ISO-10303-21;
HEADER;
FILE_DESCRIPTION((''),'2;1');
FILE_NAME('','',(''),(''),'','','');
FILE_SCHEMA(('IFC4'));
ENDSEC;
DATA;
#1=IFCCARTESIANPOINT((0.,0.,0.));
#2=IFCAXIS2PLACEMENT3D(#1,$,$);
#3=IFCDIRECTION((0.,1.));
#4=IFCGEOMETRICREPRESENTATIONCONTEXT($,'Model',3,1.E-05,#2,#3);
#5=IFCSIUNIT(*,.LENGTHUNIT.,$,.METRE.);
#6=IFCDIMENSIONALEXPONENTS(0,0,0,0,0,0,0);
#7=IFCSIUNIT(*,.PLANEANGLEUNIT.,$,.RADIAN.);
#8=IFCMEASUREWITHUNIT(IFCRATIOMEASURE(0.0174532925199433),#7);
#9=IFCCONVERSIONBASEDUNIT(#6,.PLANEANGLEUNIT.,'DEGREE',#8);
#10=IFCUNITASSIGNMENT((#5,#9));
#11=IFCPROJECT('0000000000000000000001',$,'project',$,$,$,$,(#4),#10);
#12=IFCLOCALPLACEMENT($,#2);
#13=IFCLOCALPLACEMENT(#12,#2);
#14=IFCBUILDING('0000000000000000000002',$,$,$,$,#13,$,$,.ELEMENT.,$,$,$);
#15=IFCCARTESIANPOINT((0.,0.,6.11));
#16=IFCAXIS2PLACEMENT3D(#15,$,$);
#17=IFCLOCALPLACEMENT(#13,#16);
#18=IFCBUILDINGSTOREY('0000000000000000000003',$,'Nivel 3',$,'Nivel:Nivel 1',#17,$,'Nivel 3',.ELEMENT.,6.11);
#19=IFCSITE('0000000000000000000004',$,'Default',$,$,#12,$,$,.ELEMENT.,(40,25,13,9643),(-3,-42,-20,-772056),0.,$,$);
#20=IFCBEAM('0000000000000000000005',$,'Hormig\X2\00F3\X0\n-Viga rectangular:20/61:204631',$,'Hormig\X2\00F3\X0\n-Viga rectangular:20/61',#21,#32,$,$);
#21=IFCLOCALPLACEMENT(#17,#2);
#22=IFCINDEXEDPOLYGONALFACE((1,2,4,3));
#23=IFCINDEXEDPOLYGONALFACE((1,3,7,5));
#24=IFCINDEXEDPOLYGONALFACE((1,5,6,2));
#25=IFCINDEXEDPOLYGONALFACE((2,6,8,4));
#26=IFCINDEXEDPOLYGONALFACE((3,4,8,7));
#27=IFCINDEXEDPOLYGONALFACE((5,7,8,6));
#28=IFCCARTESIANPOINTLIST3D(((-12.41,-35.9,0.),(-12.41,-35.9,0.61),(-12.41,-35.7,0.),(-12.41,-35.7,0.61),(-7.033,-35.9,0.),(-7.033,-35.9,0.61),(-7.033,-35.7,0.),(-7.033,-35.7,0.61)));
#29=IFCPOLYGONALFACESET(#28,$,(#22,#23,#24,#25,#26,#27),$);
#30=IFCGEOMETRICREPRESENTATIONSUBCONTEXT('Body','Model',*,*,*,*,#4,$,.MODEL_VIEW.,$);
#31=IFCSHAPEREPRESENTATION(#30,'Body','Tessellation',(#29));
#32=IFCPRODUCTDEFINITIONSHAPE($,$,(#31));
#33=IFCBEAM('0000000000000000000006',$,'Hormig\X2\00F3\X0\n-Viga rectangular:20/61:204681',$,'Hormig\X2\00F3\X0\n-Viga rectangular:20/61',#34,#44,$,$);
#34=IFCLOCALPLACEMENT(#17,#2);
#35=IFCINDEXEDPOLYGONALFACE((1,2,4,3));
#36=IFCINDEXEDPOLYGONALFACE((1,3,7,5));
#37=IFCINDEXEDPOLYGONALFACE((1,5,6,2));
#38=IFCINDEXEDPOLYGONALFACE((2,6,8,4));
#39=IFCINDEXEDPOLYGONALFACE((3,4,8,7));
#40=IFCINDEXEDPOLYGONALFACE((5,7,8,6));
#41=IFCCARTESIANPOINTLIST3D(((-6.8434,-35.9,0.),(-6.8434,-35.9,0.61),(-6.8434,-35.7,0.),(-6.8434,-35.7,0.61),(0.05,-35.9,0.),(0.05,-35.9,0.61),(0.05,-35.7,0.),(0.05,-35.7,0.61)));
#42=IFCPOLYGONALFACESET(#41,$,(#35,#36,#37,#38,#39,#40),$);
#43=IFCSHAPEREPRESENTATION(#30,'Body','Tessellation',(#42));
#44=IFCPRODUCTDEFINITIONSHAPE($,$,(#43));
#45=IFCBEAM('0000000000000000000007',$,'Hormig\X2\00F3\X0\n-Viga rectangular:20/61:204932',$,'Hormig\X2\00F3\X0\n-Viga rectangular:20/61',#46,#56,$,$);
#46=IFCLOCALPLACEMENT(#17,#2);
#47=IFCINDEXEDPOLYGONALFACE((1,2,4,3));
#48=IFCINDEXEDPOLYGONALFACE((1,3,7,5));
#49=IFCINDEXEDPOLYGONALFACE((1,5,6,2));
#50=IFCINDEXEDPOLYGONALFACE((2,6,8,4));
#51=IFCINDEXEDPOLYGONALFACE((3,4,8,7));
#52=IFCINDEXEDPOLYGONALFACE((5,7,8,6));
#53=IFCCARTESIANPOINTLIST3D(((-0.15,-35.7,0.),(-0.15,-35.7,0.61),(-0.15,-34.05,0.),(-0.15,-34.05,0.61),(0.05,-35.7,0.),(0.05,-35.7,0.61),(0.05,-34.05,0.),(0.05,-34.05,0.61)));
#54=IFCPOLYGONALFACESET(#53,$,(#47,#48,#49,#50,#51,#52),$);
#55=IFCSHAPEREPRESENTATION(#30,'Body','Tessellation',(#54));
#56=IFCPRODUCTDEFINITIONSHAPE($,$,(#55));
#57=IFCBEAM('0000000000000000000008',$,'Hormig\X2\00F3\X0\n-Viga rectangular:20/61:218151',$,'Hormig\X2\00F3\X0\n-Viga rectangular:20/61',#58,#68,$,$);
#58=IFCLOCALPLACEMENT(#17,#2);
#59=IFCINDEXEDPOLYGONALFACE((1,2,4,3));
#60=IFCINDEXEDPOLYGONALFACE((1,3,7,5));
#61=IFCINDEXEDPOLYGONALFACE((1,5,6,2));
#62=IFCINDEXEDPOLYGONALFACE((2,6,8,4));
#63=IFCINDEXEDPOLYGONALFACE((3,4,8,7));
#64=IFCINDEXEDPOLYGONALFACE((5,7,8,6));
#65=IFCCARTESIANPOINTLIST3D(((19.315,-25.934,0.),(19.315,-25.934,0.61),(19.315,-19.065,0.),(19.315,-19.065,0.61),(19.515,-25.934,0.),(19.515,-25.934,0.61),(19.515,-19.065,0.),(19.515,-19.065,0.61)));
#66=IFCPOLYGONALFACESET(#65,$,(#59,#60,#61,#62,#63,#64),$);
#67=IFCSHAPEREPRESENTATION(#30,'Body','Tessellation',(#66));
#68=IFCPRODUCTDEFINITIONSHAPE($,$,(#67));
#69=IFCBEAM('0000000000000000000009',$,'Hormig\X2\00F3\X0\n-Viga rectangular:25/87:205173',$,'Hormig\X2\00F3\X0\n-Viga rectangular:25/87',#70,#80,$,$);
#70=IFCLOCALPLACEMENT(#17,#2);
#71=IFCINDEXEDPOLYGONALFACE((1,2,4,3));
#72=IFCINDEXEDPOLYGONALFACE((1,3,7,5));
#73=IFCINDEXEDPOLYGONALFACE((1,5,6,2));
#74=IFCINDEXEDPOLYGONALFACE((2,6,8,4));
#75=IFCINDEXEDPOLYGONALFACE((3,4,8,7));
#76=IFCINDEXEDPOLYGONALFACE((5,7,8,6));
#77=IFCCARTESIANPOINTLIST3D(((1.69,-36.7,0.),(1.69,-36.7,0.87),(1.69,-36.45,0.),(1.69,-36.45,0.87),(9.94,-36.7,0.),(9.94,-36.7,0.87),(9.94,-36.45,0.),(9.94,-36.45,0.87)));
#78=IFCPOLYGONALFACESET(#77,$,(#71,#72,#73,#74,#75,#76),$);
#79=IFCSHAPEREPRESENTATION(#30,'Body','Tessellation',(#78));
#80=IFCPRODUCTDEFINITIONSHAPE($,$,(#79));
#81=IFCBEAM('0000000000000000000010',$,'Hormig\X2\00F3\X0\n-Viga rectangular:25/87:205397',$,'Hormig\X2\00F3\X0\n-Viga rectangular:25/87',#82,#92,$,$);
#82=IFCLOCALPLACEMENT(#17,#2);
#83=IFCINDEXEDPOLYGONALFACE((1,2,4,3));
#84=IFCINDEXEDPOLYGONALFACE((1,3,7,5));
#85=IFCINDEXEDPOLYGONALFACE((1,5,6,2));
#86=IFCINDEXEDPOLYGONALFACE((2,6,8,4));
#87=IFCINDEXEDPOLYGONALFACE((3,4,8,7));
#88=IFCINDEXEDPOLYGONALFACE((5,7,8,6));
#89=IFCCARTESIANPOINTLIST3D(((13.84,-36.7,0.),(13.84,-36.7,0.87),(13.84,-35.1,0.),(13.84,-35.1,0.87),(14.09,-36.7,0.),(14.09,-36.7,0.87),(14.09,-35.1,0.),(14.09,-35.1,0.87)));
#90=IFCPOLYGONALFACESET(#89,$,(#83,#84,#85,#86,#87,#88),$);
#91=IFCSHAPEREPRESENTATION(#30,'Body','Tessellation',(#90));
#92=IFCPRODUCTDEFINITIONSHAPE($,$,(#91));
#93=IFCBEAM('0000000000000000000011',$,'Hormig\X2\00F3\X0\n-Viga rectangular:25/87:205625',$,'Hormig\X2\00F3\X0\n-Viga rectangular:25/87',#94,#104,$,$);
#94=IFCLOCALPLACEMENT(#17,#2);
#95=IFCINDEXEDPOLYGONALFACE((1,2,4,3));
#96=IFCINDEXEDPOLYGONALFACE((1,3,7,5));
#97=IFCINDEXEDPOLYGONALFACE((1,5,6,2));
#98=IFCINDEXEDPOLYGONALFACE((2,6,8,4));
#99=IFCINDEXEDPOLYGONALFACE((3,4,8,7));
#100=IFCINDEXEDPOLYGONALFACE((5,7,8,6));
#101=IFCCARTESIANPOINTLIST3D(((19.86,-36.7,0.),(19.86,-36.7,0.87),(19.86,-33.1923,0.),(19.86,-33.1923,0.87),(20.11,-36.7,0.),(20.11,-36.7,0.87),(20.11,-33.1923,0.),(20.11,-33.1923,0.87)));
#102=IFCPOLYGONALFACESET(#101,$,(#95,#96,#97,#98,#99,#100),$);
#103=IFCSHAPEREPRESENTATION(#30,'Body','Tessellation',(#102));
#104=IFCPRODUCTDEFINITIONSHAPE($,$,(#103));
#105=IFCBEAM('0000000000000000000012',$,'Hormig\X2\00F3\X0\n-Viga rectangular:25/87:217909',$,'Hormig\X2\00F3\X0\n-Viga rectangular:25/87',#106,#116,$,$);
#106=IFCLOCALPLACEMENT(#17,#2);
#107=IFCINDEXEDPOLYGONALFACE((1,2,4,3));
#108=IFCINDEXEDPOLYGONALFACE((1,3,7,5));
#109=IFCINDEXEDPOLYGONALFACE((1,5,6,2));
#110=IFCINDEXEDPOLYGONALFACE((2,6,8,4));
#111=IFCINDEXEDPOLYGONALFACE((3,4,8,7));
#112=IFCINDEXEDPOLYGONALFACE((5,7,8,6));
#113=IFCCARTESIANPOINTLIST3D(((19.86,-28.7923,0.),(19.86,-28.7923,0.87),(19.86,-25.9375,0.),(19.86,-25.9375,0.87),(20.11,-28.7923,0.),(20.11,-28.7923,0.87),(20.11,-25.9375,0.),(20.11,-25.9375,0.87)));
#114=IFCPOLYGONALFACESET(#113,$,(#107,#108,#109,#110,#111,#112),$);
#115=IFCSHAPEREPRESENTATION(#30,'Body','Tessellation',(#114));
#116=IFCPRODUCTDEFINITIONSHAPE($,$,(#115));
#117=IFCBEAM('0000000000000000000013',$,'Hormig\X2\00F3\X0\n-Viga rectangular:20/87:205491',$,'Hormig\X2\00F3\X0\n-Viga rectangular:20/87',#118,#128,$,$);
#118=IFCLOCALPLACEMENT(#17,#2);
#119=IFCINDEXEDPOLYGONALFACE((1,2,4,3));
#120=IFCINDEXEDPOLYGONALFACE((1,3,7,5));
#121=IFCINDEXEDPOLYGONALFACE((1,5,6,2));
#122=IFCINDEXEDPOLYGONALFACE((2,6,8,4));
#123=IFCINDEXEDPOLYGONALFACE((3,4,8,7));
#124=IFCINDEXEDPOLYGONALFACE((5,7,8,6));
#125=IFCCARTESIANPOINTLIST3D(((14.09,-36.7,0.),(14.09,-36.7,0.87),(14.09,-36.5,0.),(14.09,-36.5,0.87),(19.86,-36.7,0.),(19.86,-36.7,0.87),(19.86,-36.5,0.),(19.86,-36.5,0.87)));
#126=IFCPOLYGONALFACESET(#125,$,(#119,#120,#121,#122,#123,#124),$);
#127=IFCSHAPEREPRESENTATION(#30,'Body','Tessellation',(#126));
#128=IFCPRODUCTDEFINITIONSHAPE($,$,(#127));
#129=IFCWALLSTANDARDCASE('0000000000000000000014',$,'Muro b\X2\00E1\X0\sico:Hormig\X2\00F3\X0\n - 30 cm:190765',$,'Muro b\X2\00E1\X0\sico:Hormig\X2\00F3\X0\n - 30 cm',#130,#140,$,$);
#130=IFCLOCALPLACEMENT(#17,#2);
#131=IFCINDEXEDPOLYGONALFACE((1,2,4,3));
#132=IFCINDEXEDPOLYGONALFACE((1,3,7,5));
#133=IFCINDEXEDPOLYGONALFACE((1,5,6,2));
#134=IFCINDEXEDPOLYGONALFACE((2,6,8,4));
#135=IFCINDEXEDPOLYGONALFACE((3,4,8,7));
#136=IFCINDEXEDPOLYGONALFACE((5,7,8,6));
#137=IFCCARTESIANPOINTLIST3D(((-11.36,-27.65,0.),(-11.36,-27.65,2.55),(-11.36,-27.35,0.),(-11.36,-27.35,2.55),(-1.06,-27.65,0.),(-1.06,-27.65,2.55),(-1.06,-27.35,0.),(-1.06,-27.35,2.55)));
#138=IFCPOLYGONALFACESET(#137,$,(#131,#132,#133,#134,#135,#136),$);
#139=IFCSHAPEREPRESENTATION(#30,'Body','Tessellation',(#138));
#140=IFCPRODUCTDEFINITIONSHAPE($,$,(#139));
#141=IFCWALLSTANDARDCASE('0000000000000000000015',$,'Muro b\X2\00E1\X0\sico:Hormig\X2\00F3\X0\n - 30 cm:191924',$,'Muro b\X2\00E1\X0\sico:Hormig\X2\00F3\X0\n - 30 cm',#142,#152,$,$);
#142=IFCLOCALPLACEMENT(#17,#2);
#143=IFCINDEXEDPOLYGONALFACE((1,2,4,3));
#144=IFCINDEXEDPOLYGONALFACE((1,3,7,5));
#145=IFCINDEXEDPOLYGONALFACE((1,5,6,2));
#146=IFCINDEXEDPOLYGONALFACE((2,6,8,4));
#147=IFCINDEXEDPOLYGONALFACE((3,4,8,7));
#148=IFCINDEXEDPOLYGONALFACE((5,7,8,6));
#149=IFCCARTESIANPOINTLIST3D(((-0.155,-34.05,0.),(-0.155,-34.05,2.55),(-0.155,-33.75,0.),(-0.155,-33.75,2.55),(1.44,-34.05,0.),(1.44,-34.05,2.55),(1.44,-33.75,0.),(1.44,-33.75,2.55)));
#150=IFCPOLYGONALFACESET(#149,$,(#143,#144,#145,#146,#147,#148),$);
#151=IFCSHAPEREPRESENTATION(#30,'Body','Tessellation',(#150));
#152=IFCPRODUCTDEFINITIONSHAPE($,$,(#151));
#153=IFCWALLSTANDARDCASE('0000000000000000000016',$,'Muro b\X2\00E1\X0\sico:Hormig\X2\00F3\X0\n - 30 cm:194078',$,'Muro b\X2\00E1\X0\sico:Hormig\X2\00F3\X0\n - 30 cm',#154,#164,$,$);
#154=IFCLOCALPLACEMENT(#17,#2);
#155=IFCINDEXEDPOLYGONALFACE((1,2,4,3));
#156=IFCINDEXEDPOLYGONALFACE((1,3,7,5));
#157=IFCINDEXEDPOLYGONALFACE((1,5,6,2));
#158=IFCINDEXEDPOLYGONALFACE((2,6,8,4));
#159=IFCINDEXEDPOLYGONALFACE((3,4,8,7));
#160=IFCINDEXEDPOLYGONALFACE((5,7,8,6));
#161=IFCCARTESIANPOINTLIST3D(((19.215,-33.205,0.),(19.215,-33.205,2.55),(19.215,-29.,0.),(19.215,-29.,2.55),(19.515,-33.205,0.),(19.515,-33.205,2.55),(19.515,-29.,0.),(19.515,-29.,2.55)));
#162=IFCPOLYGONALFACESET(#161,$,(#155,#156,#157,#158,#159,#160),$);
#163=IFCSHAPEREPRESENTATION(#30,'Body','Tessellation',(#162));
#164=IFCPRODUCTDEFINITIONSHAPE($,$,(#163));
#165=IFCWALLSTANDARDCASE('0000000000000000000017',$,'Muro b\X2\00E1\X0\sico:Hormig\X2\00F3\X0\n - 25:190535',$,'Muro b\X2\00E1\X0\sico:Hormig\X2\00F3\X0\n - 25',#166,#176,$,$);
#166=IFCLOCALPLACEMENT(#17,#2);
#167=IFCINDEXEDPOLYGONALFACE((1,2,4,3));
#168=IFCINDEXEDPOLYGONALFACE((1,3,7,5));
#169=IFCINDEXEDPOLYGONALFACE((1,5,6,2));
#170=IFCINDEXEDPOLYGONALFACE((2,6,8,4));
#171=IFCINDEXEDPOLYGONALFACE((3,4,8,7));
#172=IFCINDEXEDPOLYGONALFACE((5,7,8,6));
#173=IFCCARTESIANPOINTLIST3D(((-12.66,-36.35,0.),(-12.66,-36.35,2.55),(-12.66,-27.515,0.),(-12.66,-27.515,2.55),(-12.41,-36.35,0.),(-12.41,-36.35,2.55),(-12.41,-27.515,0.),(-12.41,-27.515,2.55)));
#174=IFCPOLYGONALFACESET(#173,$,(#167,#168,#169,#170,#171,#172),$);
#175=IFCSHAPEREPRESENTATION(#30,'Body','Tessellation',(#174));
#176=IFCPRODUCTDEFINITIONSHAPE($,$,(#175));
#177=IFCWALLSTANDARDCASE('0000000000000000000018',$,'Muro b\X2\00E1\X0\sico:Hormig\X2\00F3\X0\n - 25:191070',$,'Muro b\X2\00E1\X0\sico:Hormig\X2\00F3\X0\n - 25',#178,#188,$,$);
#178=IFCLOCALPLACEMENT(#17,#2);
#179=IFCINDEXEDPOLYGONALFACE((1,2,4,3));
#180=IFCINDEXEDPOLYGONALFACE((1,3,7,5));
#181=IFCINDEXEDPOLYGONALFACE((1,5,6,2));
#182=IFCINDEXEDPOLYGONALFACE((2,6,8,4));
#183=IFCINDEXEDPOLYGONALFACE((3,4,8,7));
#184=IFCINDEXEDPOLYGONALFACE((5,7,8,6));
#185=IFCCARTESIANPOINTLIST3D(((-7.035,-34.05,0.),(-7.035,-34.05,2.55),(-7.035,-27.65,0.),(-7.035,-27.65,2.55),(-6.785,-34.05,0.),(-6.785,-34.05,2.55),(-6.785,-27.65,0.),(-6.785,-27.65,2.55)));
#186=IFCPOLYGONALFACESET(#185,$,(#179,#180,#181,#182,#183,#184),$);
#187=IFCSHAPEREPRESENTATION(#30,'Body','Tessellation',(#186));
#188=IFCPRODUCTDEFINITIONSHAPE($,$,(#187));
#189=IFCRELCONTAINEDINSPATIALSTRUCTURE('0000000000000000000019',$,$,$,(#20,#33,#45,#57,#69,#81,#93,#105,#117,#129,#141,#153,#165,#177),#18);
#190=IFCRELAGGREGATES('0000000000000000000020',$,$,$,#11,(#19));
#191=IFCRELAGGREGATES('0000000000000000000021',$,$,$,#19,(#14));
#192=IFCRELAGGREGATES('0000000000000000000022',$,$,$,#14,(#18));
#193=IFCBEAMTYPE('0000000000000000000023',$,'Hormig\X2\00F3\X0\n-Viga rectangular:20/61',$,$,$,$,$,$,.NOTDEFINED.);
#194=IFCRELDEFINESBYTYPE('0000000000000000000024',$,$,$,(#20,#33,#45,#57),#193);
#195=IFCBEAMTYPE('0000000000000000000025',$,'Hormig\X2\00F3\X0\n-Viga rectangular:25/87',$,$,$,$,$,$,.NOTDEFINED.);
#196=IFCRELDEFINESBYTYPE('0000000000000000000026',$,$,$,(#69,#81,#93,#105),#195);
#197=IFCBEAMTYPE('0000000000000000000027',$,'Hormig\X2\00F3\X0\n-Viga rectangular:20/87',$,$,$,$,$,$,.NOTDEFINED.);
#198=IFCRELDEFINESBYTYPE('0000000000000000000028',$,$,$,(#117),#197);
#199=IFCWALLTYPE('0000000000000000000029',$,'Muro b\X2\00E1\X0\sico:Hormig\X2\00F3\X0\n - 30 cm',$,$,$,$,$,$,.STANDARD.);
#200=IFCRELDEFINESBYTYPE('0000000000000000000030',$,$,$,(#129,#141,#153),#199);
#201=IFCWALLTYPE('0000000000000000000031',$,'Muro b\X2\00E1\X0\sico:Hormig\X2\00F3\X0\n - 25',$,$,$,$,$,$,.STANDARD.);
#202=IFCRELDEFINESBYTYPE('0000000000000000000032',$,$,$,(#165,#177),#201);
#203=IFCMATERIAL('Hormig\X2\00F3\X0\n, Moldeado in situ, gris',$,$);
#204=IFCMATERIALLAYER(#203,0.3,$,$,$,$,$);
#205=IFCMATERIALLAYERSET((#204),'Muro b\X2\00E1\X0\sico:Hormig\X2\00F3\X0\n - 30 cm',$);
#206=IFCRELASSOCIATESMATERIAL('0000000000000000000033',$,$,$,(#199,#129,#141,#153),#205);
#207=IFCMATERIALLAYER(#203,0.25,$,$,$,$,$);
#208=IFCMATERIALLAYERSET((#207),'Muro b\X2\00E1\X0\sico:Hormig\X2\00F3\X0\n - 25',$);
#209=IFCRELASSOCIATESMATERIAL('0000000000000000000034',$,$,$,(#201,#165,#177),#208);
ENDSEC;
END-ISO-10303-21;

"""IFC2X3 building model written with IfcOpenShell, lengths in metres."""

from ifc_helpers import new_model, entity, si_unit, converted_unit, direction, frame, frame_2d, origin, origin_2d_with_axis, place, context, subcontext, project, spatial, rectangle, extrude, material, layer, layer_set, layer_usage, type_object, element, save


model = new_model("IFC2X3")

# Units and contexts
model_context = context("Model", 3, precision=1e-05, world=origin(), true_north=direction((0.0, 1.0)))
body_context = subcontext(model_context, "Body", "Model", "MODEL_VIEW")
ifc_project = project(units=[si_unit("LENGTHUNIT", "METRE"), converted_unit("PLANEANGLEUNIT", "DEGREE", entity("IfcRatioMeasure", 0.0174532925199433), si_unit("PLANEANGLEUNIT", "RADIAN"), dimensions=[0, 0, 0, 0, 0, 0, 0])], contexts=[model_context])

# Site, building, storey
site_placement = place(None, origin())
site = spatial("IfcSite", under=ifc_project, at=site_placement, Name="Default", CompositionType="ELEMENT", RefLatitude=(40, 25, 13, 9643), RefLongitude=(-3, -42, -20, -772056), RefElevation=0.0)
building_placement = place(site_placement, origin())
building = spatial("IfcBuilding", under=site, at=building_placement, CompositionType="ELEMENT")
storey_placement = place(building_placement, frame((0.0, 0.0, 6.11)))
storey = spatial("IfcBuildingStorey", under=building, at=storey_placement, Name="Nivel 3", ObjectType="Nivel:Nivel 1", LongName="Nivel 3", CompositionType="ELEMENT", Elevation=6.11)

# Beams
beam_type_1 = type_object("IfcBeamType", Name="Hormigón-Viga rectangular:20/61", PredefinedType="NOTDEFINED")
beam_1_placement = place(storey_placement, frame((-12.4857, -35.8, 0.61)))
element("IfcBeam", 1, at=beam_1_placement, inside=storey, type_object=beam_type_1, Name="Hormigón-Viga rectangular:20/61:204631", ObjectType="Hormigón-Viga rectangular:20/61", context=body_context, shape_type="SweptSolid", body=[
    extrude(rectangle(XDim=0.61, YDim=0.2, at=frame_2d((0.0, 0.0), x_axis=(1.0, 0.0))), frame((0.0757, 0.0, -0.305), z_axis=(1.0, 0.0, 0.0), x_axis=(0.0, 0.0, -1.0)), (0.0, 0.0, 1.0), 5.377),
])
beam_2_placement = place(storey_placement, frame((-6.8307, -35.8, 0.61)))
element("IfcBeam", 2, at=beam_2_placement, inside=storey, type_object=beam_type_1, Name="Hormigón-Viga rectangular:20/61:204681", ObjectType="Hormigón-Viga rectangular:20/61", context=body_context, shape_type="SweptSolid", body=[
    extrude(rectangle(XDim=0.61, YDim=0.2, at=frame_2d((0.0, 0.0), x_axis=(1.0, 0.0))), frame((-0.0127, 0.0, -0.305), z_axis=(1.0, 0.0, 0.0), x_axis=(0.0, 0.0, -1.0)), (0.0, 0.0, 1.0), 6.8934),
])
beam_3_placement = place(storey_placement, frame((-0.05, -35.8, 0.61), z_axis=(0.0, 0.0, 1.0), x_axis=(0.0, 1.0, 0.0)))
element("IfcBeam", 3, at=beam_3_placement, inside=storey, type_object=beam_type_1, Name="Hormigón-Viga rectangular:20/61:204932", ObjectType="Hormigón-Viga rectangular:20/61", context=body_context, shape_type="SweptSolid", body=[
    extrude(rectangle(XDim=0.61, YDim=0.2, at=origin_2d_with_axis()), frame((0.1, 0.0, -0.305), z_axis=(1.0, 0.0, 0.0), x_axis=(0.0, 0.0, -1.0)), (0.0, 0.0, 1.0), 1.65),
])
beam_4_placement = place(storey_placement, frame((19.415, -25.9216, 0.61), z_axis=(0.0, 0.0, 1.0), x_axis=(0.0, 1.0, 0.0)))
element("IfcBeam", 4, at=beam_4_placement, inside=storey, type_object=beam_type_1, Name="Hormigón-Viga rectangular:20/61:218151", ObjectType="Hormigón-Viga rectangular:20/61", context=body_context, shape_type="SweptSolid", body=[
    extrude(rectangle(XDim=0.61, YDim=0.2, at=origin_2d_with_axis()), frame((-0.0124, 0.0, -0.305), z_axis=(1.0, 0.0, 0.0), x_axis=(0.0, 0.0, -1.0)), (0.0, 0.0, 1.0), 6.869),
])
beam_type_2 = type_object("IfcBeamType", Name="Hormigón-Viga rectangular:25/87", PredefinedType="NOTDEFINED")
beam_5_placement = place(storey_placement, frame((1.565, -36.575, 0.87)))
element("IfcBeam", 5, at=beam_5_placement, inside=storey, type_object=beam_type_2, Name="Hormigón-Viga rectangular:25/87:205173", ObjectType="Hormigón-Viga rectangular:25/87", context=body_context, shape_type="SweptSolid", body=[
    extrude(rectangle(XDim=0.87, YDim=0.25, at=frame_2d((0.0, 0.0), x_axis=(1.0, 0.0))), frame((0.125, 0.0, -0.435), z_axis=(1.0, 0.0, 0.0), x_axis=(0.0, 0.0, -1.0)), (0.0, 0.0, 1.0), 8.25),
])
beam_6_placement = place(storey_placement, frame((13.965, -34.975, 0.87), z_axis=(0.0, 0.0, 1.0), x_axis=(0.0, -1.0, 0.0)))
element("IfcBeam", 6, at=beam_6_placement, inside=storey, type_object=beam_type_2, Name="Hormigón-Viga rectangular:25/87:205397", ObjectType="Hormigón-Viga rectangular:25/87", context=body_context, shape_type="SweptSolid", body=[
    extrude(rectangle(XDim=0.87, YDim=0.25, at=origin_2d_with_axis()), frame((0.125, 0.0, -0.435), z_axis=(1.0, 0.0, 0.0), x_axis=(0.0, 0.0, -1.0)), (0.0, 0.0, 1.0), 1.6),
])
beam_7_placement = place(storey_placement, frame((19.985, -33.1923, 0.87), z_axis=(0.0, 0.0, 1.0), x_axis=(0.0, -1.0, 0.0)))
element("IfcBeam", 7, at=beam_7_placement, inside=storey, type_object=beam_type_2, Name="Hormigón-Viga rectangular:25/87:205625", ObjectType="Hormigón-Viga rectangular:25/87", context=body_context, shape_type="SweptSolid", body=[
    extrude(rectangle(XDim=0.87, YDim=0.25, at=origin_2d_with_axis()), frame((0.0, 0.0, -0.435), z_axis=(1.0, 0.0, 0.0), x_axis=(0.0, 0.0, -1.0)), (0.0, 0.0, 1.0), 3.5077),
])
beam_8_placement = place(storey_placement, frame((19.985, -25.95, 0.87), z_axis=(0.0, 0.0, 1.0), x_axis=(0.0, -1.0, 0.0)))
element("IfcBeam", 8, at=beam_8_placement, inside=storey, type_object=beam_type_2, Name="Hormigón-Viga rectangular:25/87:217909", ObjectType="Hormigón-Viga rectangular:25/87", context=body_context, shape_type="SweptSolid", body=[
    extrude(rectangle(XDim=0.87, YDim=0.25, at=origin_2d_with_axis()), frame((-0.0126, 0.0, -0.435), z_axis=(1.0, 0.0, 0.0), x_axis=(0.0, 0.0, -1.0)), (0.0, 0.0, 1.0), 2.8548),
])
beam_type_3 = type_object("IfcBeamType", Name="Hormigón-Viga rectangular:20/87", PredefinedType="NOTDEFINED")
beam_9_placement = place(storey_placement, frame((13.965, -36.6, 0.87)))
element("IfcBeam", 9, at=beam_9_placement, inside=storey, type_object=beam_type_3, Name="Hormigón-Viga rectangular:20/87:205491", ObjectType="Hormigón-Viga rectangular:20/87", context=body_context, shape_type="SweptSolid", body=[
    extrude(rectangle(XDim=0.87, YDim=0.2, at=frame_2d((0.0, 0.0), x_axis=(1.0, 0.0))), frame((0.125, 0.0, -0.435), z_axis=(1.0, 0.0, 0.0), x_axis=(0.0, 0.0, -1.0)), (0.0, 0.0, 1.0), 5.77),
])

# Walls
ifc_material = material(Name="Hormigón, Moldeado in situ, gris")
ifc_layer_1 = layer(ifc_material, 0.3)
ifc_layer_set_1 = layer_set([ifc_layer_1], Name="Muro básico:Hormigón - 30 cm")
ifc_layer_usage_1 = layer_usage(ifc_layer_set_1, "AXIS2", "NEGATIVE", 0.15)
wall_type_1 = type_object("IfcWallType", Name="Muro básico:Hormigón - 30 cm", PredefinedType="STANDARD", material=ifc_layer_set_1)
wall_1_placement = place(storey_placement, frame((-11.36, -27.5, 0.0)))
element("IfcWallStandardCase", 10, at=wall_1_placement, inside=storey, type_object=wall_type_1, material=ifc_layer_usage_1, Name="Muro básico:Hormigón - 30 cm:190765", ObjectType="Muro básico:Hormigón - 30 cm", context=body_context, shape_type="SweptSolid", body=[
    extrude(rectangle(XDim=10.3, YDim=0.3, at=frame_2d((5.15, 0.0), x_axis=(-1.0, 0.0))), origin(), (0.0, 0.0, 1.0), 2.55),
])
ifc_layer_usage_2 = layer_usage(ifc_layer_set_1, "AXIS2", "NEGATIVE", 0.15)
wall_2_placement = place(storey_placement, frame((-0.155, -33.9, 0.0)))
element("IfcWallStandardCase", 11, at=wall_2_placement, inside=storey, type_object=wall_type_1, material=ifc_layer_usage_2, Name="Muro básico:Hormigón - 30 cm:191924", ObjectType="Muro básico:Hormigón - 30 cm", context=body_context, shape_type="SweptSolid", body=[
    extrude(rectangle(XDim=1.595, YDim=0.3, at=frame_2d((0.7975, 0.0), x_axis=(-1.0, 0.0))), origin(), (0.0, 0.0, 1.0), 2.55),
])
ifc_layer_usage_3 = layer_usage(ifc_layer_set_1, "AXIS2", "NEGATIVE", 0.15)
wall_3_placement = place(storey_placement, frame((19.365, -33.205, 0.0), z_axis=(0.0, 0.0, 1.0), x_axis=(0.0, 1.0, 0.0)))
element("IfcWallStandardCase", 12, at=wall_3_placement, inside=storey, type_object=wall_type_1, material=ifc_layer_usage_3, Name="Muro básico:Hormigón - 30 cm:194078", ObjectType="Muro básico:Hormigón - 30 cm", context=body_context, shape_type="SweptSolid", body=[
    extrude(rectangle(XDim=4.205, YDim=0.3, at=frame_2d((2.1025, 0.0), x_axis=(-1.0, 0.0))), origin(), (0.0, 0.0, 1.0), 2.55),
])
ifc_layer_2 = layer(ifc_material, 0.25)
ifc_layer_set_2 = layer_set([ifc_layer_2], Name="Muro básico:Hormigón - 25")
ifc_layer_usage_4 = layer_usage(ifc_layer_set_2, "AXIS2", "NEGATIVE", 0.125)
wall_type_2 = type_object("IfcWallType", Name="Muro básico:Hormigón - 25", PredefinedType="STANDARD", material=ifc_layer_set_2)
wall_4_placement = place(storey_placement, frame((-12.535, -27.515, 0.0), z_axis=(0.0, 0.0, 1.0), x_axis=(0.0, -1.0, 0.0)))
element("IfcWallStandardCase", 13, at=wall_4_placement, inside=storey, type_object=wall_type_2, material=ifc_layer_usage_4, Name="Muro básico:Hormigón - 25:190535", ObjectType="Muro básico:Hormigón - 25", context=body_context, shape_type="SweptSolid", body=[
    extrude(rectangle(XDim=8.835, YDim=0.25, at=frame_2d((4.4175, 0.0), x_axis=(-1.0, 0.0))), origin(), (0.0, 0.0, 1.0), 2.55),
])
ifc_layer_usage_5 = layer_usage(ifc_layer_set_2, "AXIS2", "NEGATIVE", 0.125)
wall_5_placement = place(storey_placement, frame((-6.91, -27.65, 0.0), z_axis=(0.0, 0.0, 1.0), x_axis=(0.0, -1.0, 0.0)))
element("IfcWallStandardCase", 14, at=wall_5_placement, inside=storey, type_object=wall_type_2, material=ifc_layer_usage_5, Name="Muro básico:Hormigón - 25:191070", ObjectType="Muro básico:Hormigón - 25", context=body_context, shape_type="SweptSolid", body=[
    extrude(rectangle(XDim=6.4, YDim=0.25, at=frame_2d((3.2, 0.0), x_axis=(-1.0, 0.0))), origin(), (0.0, 0.0, 1.0), 2.55),
])

save(model, "model.ifc")
